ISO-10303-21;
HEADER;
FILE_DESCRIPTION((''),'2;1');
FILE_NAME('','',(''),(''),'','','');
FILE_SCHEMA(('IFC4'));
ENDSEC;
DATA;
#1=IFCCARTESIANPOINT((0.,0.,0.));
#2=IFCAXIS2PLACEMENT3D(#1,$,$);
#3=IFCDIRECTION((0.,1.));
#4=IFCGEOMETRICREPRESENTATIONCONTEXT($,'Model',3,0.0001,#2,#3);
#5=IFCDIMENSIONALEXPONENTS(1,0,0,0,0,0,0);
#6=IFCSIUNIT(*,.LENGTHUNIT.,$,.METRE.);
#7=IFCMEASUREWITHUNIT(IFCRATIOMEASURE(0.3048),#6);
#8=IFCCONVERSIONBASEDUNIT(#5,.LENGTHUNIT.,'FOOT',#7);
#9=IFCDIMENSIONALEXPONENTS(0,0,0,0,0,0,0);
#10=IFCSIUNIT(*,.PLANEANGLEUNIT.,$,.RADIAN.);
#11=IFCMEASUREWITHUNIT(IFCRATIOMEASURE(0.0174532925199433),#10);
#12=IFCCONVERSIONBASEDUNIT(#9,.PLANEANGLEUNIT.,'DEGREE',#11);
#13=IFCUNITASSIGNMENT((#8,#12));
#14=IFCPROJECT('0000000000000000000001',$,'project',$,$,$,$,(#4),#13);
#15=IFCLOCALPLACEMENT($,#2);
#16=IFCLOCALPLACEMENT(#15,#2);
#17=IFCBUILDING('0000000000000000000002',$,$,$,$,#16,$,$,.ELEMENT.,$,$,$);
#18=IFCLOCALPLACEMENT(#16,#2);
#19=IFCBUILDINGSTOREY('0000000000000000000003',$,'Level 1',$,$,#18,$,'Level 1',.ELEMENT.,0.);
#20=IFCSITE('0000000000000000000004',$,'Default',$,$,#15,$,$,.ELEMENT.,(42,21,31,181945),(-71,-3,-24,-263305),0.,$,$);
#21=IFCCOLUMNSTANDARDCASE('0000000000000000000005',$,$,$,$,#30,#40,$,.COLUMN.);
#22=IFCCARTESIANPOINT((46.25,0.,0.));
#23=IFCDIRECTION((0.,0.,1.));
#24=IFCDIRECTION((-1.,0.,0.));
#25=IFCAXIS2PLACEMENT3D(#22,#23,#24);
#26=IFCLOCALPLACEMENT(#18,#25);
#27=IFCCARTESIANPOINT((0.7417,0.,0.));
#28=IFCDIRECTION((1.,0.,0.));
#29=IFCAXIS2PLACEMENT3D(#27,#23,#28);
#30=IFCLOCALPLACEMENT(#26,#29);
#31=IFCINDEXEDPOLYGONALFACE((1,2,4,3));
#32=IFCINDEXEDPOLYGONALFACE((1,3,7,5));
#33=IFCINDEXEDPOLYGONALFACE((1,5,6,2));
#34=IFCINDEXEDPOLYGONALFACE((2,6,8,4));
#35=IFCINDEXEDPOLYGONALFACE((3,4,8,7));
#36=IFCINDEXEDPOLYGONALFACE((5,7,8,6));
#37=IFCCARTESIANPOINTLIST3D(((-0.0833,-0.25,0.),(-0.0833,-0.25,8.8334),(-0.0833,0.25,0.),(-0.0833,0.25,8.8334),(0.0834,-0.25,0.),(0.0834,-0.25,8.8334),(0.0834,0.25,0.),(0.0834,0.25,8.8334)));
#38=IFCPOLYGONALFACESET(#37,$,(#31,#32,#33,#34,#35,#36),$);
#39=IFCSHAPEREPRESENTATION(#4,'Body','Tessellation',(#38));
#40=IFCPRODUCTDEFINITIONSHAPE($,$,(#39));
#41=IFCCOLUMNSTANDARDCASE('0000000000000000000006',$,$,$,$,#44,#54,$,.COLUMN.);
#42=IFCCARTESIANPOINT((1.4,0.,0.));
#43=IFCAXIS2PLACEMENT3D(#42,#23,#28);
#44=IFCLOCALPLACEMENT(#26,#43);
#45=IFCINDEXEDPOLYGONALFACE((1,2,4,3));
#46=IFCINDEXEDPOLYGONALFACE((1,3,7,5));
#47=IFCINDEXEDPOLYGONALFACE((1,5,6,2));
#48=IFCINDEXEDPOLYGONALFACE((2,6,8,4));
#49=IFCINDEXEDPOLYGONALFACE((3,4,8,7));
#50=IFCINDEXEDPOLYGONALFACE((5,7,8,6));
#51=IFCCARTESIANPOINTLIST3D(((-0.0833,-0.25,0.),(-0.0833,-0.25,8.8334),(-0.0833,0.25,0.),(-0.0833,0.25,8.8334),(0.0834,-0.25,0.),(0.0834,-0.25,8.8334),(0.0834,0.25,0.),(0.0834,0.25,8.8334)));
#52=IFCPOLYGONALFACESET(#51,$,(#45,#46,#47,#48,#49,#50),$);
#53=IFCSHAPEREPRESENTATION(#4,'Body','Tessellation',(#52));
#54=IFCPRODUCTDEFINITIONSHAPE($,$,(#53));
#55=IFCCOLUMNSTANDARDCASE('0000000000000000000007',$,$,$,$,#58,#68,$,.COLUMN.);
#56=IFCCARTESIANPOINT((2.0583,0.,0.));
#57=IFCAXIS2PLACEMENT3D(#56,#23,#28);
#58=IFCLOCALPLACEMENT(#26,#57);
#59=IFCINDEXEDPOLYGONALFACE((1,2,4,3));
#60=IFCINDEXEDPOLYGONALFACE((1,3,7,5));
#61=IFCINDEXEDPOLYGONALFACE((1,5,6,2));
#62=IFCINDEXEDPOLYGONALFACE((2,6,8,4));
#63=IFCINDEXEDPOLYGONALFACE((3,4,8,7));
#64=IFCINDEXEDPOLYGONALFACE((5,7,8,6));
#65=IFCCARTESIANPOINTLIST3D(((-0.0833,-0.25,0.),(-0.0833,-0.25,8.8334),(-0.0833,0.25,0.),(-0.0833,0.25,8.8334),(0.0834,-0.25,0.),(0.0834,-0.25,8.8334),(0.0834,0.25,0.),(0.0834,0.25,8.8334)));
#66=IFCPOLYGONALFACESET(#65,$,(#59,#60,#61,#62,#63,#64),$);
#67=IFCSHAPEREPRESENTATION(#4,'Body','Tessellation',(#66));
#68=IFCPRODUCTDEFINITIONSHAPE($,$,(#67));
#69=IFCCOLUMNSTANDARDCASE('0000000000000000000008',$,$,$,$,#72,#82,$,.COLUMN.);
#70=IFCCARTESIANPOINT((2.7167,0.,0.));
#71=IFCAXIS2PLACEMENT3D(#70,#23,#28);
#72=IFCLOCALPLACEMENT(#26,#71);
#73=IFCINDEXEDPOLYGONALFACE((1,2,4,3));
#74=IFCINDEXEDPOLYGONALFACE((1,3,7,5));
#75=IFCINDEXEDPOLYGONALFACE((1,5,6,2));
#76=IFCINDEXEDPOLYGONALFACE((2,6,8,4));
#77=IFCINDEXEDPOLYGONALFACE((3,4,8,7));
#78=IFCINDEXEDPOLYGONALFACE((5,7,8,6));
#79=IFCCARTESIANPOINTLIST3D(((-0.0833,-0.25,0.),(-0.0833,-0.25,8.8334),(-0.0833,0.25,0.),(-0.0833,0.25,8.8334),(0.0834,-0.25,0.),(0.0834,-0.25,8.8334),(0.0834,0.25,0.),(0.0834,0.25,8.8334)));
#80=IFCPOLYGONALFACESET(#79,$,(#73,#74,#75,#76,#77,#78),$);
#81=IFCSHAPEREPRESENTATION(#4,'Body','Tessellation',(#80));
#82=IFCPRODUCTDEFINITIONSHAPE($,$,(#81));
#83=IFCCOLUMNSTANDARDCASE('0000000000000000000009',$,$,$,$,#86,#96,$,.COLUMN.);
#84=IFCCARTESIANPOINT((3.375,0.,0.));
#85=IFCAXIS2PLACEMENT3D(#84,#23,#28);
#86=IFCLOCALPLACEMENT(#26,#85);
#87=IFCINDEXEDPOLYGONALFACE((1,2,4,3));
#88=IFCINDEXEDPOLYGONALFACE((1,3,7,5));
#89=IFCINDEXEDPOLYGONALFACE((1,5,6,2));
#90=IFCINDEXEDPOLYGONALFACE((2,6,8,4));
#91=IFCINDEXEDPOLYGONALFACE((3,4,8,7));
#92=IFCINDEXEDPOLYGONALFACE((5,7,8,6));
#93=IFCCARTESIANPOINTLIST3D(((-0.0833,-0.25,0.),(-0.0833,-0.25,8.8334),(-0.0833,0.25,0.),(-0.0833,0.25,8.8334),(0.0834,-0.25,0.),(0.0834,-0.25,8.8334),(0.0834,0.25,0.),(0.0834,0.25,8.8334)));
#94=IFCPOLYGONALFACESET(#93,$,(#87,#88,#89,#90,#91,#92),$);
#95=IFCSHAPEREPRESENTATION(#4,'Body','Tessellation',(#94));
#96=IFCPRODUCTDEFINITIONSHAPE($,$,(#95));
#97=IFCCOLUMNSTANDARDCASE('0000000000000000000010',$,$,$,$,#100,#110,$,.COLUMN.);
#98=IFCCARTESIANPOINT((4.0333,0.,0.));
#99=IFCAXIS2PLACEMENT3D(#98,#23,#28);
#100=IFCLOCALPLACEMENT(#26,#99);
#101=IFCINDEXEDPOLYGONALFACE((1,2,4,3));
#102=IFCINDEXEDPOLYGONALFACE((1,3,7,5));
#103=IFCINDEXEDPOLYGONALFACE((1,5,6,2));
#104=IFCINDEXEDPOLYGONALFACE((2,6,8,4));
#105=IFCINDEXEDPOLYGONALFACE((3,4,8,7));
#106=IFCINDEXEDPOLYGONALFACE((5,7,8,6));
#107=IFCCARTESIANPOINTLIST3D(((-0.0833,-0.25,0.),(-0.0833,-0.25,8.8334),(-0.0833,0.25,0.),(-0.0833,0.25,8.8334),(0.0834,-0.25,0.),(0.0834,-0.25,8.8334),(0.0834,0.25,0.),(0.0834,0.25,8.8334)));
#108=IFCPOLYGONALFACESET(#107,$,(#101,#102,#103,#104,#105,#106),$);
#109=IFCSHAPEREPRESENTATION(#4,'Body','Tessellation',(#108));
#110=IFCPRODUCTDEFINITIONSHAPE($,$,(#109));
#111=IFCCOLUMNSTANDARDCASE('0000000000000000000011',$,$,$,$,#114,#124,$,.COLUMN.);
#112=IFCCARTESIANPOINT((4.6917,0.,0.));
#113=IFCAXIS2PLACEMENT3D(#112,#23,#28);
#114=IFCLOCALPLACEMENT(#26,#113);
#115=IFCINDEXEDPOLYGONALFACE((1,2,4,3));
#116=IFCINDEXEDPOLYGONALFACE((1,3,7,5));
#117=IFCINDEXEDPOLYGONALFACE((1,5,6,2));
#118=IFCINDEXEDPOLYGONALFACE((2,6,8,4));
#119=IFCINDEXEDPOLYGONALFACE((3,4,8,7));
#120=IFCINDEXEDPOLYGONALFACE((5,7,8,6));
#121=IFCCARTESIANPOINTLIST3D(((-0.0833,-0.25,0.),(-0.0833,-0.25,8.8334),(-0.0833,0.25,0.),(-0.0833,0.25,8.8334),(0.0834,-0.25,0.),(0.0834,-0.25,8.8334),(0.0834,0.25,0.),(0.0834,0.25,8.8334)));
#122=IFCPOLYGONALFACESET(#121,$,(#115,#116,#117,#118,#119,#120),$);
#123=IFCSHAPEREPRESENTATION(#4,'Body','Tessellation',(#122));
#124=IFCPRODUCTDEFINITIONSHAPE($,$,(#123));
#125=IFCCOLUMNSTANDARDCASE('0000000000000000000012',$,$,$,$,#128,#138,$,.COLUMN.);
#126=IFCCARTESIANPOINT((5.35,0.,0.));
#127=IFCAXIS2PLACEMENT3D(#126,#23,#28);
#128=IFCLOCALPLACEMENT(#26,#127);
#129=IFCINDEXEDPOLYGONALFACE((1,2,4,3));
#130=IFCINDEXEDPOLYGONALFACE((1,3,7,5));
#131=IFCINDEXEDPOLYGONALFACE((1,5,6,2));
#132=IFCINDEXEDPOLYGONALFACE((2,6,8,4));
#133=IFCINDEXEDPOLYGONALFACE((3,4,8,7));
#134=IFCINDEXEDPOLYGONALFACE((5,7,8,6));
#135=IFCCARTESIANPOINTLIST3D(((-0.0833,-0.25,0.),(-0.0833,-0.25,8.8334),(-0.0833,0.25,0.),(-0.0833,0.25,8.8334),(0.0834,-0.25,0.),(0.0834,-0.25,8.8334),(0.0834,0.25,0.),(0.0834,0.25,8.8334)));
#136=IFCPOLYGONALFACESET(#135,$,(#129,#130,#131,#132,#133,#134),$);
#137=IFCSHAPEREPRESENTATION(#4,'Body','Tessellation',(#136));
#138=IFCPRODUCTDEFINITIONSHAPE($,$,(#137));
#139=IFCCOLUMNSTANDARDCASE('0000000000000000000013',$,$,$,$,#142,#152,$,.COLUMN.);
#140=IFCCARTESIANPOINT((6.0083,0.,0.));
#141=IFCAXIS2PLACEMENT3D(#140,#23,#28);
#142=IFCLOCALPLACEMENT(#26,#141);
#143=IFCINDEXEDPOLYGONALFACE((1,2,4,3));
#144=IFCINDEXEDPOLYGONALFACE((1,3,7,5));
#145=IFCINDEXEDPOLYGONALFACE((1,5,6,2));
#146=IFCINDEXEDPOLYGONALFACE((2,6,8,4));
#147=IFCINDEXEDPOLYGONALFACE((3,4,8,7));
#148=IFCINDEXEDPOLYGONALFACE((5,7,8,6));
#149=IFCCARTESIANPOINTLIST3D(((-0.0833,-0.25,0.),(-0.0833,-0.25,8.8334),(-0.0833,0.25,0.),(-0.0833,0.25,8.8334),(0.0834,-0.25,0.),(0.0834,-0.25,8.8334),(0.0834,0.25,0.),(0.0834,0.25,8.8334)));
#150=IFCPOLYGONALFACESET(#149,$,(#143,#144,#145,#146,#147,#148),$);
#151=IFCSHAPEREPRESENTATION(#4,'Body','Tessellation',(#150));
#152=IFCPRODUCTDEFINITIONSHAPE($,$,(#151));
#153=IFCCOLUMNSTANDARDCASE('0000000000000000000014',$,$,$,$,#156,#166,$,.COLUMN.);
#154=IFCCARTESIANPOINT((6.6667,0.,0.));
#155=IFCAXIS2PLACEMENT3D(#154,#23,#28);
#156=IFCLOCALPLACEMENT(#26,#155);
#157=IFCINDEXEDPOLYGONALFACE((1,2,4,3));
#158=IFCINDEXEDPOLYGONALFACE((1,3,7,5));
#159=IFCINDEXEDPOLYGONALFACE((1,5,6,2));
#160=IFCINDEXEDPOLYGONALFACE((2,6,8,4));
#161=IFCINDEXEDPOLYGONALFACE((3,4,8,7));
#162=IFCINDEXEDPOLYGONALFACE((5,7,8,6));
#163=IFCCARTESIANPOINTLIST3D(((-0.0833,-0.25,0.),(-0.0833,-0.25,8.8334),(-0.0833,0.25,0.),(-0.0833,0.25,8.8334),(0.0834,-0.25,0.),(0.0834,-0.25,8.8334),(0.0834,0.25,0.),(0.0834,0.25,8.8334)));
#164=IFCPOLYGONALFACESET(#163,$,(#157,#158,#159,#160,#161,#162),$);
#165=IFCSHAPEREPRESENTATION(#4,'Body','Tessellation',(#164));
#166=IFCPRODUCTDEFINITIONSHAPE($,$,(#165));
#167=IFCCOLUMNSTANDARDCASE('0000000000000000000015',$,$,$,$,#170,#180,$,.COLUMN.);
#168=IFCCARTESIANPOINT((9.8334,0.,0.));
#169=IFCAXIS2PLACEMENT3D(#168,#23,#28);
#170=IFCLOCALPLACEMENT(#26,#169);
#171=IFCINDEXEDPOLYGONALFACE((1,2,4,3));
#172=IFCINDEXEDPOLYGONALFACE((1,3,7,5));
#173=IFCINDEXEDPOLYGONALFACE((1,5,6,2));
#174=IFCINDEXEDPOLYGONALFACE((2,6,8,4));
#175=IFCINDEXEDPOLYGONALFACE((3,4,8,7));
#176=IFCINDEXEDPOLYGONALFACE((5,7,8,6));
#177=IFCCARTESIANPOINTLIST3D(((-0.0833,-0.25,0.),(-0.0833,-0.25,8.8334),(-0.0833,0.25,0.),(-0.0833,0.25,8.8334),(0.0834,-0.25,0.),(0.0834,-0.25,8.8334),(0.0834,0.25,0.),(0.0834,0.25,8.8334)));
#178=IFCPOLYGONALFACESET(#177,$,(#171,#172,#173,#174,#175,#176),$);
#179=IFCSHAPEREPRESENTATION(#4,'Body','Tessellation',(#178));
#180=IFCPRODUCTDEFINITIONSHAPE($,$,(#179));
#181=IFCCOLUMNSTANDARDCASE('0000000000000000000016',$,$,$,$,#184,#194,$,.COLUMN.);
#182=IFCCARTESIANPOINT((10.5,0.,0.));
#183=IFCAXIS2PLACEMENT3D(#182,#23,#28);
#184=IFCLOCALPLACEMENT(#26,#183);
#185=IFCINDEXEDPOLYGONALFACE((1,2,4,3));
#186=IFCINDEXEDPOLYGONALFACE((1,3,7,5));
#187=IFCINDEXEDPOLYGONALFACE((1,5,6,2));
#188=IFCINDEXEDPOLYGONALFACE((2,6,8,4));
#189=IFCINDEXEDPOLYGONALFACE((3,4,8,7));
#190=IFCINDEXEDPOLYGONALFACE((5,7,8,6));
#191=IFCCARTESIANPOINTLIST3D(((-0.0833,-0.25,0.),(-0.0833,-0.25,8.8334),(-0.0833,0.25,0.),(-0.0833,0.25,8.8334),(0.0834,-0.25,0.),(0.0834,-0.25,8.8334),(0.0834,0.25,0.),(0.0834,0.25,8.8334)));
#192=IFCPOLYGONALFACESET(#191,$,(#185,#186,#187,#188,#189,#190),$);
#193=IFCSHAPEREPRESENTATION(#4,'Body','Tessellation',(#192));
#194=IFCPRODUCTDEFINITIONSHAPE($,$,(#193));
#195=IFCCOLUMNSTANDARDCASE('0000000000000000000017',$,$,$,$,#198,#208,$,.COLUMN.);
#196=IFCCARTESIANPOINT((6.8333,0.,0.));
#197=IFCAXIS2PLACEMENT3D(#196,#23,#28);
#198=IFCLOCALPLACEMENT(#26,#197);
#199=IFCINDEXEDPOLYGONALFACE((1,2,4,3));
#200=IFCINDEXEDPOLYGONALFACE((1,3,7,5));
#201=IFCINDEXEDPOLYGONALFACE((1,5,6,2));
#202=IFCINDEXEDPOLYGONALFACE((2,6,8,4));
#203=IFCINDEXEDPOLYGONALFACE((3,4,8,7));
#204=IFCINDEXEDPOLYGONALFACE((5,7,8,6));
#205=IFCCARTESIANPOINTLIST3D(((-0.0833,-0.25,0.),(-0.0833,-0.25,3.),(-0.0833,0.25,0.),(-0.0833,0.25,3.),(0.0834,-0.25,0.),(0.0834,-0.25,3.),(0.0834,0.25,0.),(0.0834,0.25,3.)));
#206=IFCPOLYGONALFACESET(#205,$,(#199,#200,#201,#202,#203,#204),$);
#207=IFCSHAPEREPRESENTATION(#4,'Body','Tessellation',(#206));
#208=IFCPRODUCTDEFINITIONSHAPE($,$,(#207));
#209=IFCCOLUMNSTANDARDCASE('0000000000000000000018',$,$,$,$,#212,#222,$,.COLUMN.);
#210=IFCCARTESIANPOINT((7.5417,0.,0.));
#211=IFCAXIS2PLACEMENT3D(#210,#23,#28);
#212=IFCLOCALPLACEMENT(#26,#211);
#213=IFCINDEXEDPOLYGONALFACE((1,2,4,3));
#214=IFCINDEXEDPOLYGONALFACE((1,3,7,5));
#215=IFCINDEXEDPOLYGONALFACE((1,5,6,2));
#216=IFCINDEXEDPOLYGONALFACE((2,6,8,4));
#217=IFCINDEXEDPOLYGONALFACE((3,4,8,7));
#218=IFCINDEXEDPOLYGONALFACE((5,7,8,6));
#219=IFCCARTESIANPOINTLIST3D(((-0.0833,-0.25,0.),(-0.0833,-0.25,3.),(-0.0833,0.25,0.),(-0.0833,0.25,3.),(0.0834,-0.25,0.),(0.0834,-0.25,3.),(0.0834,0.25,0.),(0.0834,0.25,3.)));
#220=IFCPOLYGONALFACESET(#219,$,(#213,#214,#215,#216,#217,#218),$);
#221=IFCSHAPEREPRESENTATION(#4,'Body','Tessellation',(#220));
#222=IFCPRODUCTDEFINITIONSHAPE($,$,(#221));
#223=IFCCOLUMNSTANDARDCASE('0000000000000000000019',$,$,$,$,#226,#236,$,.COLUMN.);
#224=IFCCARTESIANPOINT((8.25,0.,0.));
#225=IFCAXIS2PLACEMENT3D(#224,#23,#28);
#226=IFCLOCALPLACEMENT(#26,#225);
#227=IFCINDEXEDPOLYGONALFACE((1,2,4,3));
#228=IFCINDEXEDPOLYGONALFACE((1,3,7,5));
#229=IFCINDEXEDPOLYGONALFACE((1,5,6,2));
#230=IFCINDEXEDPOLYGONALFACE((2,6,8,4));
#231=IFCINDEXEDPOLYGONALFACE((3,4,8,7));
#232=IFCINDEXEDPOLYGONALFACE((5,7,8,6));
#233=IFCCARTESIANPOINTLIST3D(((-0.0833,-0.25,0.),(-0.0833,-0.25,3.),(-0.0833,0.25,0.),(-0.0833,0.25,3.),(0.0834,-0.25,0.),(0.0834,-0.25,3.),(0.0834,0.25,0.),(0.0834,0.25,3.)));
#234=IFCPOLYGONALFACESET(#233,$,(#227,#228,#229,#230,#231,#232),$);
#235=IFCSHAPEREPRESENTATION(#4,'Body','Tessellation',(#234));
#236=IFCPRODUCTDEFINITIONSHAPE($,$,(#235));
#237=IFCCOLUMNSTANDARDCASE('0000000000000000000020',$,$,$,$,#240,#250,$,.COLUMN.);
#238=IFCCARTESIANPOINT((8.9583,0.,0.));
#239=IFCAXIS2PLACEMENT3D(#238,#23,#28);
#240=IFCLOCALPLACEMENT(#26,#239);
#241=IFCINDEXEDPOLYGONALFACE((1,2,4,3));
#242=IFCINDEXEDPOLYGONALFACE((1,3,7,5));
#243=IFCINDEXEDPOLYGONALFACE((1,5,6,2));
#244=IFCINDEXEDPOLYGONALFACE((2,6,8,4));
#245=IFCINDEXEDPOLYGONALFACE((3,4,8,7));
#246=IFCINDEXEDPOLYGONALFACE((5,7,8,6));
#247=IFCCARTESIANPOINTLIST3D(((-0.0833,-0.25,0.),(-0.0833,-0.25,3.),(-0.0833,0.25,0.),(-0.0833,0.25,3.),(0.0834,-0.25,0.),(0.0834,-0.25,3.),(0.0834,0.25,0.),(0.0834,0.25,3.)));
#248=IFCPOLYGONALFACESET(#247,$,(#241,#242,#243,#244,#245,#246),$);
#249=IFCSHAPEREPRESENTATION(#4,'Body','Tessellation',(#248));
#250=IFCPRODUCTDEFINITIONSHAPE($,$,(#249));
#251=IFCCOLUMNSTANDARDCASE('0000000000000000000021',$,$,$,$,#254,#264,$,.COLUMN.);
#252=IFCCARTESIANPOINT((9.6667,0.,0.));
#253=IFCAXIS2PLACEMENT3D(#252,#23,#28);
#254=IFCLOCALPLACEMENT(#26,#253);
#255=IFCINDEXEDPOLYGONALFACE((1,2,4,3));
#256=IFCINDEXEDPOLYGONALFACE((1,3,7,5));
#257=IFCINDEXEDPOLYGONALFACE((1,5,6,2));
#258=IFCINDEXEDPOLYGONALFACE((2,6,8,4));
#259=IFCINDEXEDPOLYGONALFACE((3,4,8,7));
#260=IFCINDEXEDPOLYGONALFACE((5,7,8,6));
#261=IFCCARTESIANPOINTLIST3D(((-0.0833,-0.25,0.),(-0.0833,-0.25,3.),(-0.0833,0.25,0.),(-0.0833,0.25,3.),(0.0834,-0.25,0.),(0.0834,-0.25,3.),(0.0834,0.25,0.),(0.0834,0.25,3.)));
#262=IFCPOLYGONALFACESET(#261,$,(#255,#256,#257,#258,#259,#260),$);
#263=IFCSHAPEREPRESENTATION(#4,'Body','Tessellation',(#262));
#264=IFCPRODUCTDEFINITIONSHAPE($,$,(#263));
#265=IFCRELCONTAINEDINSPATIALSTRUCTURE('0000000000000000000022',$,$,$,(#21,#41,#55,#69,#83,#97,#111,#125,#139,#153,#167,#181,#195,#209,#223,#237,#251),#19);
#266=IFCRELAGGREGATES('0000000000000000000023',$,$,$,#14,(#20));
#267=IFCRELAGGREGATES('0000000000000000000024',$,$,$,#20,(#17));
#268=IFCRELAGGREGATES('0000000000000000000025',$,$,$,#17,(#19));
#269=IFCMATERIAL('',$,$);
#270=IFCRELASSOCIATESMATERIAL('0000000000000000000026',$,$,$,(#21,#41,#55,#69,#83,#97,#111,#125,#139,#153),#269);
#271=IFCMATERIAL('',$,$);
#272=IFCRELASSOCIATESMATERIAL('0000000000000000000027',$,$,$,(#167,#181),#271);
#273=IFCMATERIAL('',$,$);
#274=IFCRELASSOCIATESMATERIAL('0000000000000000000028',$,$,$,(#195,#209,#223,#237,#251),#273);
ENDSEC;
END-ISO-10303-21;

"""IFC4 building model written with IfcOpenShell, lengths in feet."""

from ifc_helpers import new_model, entity, si_unit, converted_unit, direction, frame, origin, place, context, project, spatial, rectangle, extrude, material, element, save


model = new_model("IFC4")

# Units and contexts
model_context = context("Model", 3, precision=0.0001, world=origin(), true_north=direction((0.0, 1.0)))
ifc_project = project(units=[converted_unit("LENGTHUNIT", "FOOT", entity("IfcRatioMeasure", 0.3048), si_unit("LENGTHUNIT", "METRE"), dimensions=[1, 0, 0, 0, 0, 0, 0]), converted_unit("PLANEANGLEUNIT", "DEGREE", entity("IfcRatioMeasure", 0.0174532925199433), si_unit("PLANEANGLEUNIT", "RADIAN"), dimensions=[0, 0, 0, 0, 0, 0, 0])], contexts=[model_context])

# Site, building, storey
site_placement = place(None, origin())
site = spatial("IfcSite", under=ifc_project, at=site_placement, Name="Default", CompositionType="ELEMENT", RefLatitude=(42, 21, 31, 181945), RefLongitude=(-71, -3, -24, -263305), RefElevation=0.0)
building_placement = place(site_placement, origin())
building = spatial("IfcBuilding", under=site, at=building_placement, CompositionType="ELEMENT")
storey_placement = place(building_placement, origin())
storey = spatial("IfcBuildingStorey", under=building, at=storey_placement, Name="Level 1", LongName="Level 1", CompositionType="ELEMENT", Elevation=0.0)

# Columns
ifc_material_1 = material(Name="")
placement = place(storey_placement, frame((46.25, 0.0, 0.0), z_axis=(0.0, 0.0, 1.0), x_axis=(-1.0, 0.0, 0.0)))
for number, where, z_axis, x_axis in (
    (1, (0.7417, 0.0, 0.0), (0.0, 0.0, 1.0), (1.0, 0.0, 0.0)),
    (2, (1.4, 0.0, 0.0), (0.0, 0.0, 1.0), (1.0, 0.0, 0.0)),
    (3, (2.0583, 0.0, 0.0), (0.0, 0.0, 1.0), (1.0, 0.0, 0.0)),
    (4, (2.7167, 0.0, 0.0), (0.0, 0.0, 1.0), (1.0, 0.0, 0.0)),
    (5, (3.375, 0.0, 0.0), (0.0, 0.0, 1.0), (1.0, 0.0, 0.0)),
    (6, (4.0333, 0.0, 0.0), (0.0, 0.0, 1.0), (1.0, 0.0, 0.0)),
    (7, (4.6917, 0.0, 0.0), (0.0, 0.0, 1.0), (1.0, 0.0, 0.0)),
    (8, (5.35, 0.0, 0.0), (0.0, 0.0, 1.0), (1.0, 0.0, 0.0)),
    (9, (6.0083, 0.0, 0.0), (0.0, 0.0, 1.0), (1.0, 0.0, 0.0)),
    (10, (6.6667, 0.0, 0.0), (0.0, 0.0, 1.0), (1.0, 0.0, 0.0)),
):
    element("IfcColumnStandardCase", number, at=place(placement, frame(where, z_axis=z_axis, x_axis=x_axis)), inside=storey, material=ifc_material_1, PredefinedType="COLUMN", context=model_context, shape_type="SweptSolid", body=[
        extrude(rectangle(XDim=0.1667, YDim=0.5), origin(), (0.0, 0.0, 1.0), 8.8334),
    ])
ifc_material_2 = material(Name="")
for number, where, z_axis, x_axis in (
    (11, (9.8334, 0.0, 0.0), (0.0, 0.0, 1.0), (1.0, 0.0, 0.0)),
    (12, (10.5, 0.0, 0.0), (0.0, 0.0, 1.0), (1.0, 0.0, 0.0)),
):
    element("IfcColumnStandardCase", number, at=place(placement, frame(where, z_axis=z_axis, x_axis=x_axis)), inside=storey, material=ifc_material_2, PredefinedType="COLUMN", context=model_context, shape_type="SweptSolid", body=[
        extrude(rectangle(XDim=0.1667, YDim=0.5), origin(), (0.0, 0.0, 1.0), 8.8334),
    ])
ifc_material_3 = material(Name="")
for number, where, z_axis, x_axis in (
    (13, (6.8333, 0.0, 0.0), (0.0, 0.0, 1.0), (1.0, 0.0, 0.0)),
    (14, (7.5417, 0.0, 0.0), (0.0, 0.0, 1.0), (1.0, 0.0, 0.0)),
    (15, (8.25, 0.0, 0.0), (0.0, 0.0, 1.0), (1.0, 0.0, 0.0)),
    (16, (8.9583, 0.0, 0.0), (0.0, 0.0, 1.0), (1.0, 0.0, 0.0)),
    (17, (9.6667, 0.0, 0.0), (0.0, 0.0, 1.0), (1.0, 0.0, 0.0)),
):
    element("IfcColumnStandardCase", number, at=place(placement, frame(where, z_axis=z_axis, x_axis=x_axis)), inside=storey, material=ifc_material_3, PredefinedType="COLUMN", context=model_context, shape_type="SweptSolid", body=[
        extrude(rectangle(XDim=0.1667, YDim=0.5), origin(), (0.0, 0.0, 1.0), 3.0),
    ])

save(model, "model.ifc")
